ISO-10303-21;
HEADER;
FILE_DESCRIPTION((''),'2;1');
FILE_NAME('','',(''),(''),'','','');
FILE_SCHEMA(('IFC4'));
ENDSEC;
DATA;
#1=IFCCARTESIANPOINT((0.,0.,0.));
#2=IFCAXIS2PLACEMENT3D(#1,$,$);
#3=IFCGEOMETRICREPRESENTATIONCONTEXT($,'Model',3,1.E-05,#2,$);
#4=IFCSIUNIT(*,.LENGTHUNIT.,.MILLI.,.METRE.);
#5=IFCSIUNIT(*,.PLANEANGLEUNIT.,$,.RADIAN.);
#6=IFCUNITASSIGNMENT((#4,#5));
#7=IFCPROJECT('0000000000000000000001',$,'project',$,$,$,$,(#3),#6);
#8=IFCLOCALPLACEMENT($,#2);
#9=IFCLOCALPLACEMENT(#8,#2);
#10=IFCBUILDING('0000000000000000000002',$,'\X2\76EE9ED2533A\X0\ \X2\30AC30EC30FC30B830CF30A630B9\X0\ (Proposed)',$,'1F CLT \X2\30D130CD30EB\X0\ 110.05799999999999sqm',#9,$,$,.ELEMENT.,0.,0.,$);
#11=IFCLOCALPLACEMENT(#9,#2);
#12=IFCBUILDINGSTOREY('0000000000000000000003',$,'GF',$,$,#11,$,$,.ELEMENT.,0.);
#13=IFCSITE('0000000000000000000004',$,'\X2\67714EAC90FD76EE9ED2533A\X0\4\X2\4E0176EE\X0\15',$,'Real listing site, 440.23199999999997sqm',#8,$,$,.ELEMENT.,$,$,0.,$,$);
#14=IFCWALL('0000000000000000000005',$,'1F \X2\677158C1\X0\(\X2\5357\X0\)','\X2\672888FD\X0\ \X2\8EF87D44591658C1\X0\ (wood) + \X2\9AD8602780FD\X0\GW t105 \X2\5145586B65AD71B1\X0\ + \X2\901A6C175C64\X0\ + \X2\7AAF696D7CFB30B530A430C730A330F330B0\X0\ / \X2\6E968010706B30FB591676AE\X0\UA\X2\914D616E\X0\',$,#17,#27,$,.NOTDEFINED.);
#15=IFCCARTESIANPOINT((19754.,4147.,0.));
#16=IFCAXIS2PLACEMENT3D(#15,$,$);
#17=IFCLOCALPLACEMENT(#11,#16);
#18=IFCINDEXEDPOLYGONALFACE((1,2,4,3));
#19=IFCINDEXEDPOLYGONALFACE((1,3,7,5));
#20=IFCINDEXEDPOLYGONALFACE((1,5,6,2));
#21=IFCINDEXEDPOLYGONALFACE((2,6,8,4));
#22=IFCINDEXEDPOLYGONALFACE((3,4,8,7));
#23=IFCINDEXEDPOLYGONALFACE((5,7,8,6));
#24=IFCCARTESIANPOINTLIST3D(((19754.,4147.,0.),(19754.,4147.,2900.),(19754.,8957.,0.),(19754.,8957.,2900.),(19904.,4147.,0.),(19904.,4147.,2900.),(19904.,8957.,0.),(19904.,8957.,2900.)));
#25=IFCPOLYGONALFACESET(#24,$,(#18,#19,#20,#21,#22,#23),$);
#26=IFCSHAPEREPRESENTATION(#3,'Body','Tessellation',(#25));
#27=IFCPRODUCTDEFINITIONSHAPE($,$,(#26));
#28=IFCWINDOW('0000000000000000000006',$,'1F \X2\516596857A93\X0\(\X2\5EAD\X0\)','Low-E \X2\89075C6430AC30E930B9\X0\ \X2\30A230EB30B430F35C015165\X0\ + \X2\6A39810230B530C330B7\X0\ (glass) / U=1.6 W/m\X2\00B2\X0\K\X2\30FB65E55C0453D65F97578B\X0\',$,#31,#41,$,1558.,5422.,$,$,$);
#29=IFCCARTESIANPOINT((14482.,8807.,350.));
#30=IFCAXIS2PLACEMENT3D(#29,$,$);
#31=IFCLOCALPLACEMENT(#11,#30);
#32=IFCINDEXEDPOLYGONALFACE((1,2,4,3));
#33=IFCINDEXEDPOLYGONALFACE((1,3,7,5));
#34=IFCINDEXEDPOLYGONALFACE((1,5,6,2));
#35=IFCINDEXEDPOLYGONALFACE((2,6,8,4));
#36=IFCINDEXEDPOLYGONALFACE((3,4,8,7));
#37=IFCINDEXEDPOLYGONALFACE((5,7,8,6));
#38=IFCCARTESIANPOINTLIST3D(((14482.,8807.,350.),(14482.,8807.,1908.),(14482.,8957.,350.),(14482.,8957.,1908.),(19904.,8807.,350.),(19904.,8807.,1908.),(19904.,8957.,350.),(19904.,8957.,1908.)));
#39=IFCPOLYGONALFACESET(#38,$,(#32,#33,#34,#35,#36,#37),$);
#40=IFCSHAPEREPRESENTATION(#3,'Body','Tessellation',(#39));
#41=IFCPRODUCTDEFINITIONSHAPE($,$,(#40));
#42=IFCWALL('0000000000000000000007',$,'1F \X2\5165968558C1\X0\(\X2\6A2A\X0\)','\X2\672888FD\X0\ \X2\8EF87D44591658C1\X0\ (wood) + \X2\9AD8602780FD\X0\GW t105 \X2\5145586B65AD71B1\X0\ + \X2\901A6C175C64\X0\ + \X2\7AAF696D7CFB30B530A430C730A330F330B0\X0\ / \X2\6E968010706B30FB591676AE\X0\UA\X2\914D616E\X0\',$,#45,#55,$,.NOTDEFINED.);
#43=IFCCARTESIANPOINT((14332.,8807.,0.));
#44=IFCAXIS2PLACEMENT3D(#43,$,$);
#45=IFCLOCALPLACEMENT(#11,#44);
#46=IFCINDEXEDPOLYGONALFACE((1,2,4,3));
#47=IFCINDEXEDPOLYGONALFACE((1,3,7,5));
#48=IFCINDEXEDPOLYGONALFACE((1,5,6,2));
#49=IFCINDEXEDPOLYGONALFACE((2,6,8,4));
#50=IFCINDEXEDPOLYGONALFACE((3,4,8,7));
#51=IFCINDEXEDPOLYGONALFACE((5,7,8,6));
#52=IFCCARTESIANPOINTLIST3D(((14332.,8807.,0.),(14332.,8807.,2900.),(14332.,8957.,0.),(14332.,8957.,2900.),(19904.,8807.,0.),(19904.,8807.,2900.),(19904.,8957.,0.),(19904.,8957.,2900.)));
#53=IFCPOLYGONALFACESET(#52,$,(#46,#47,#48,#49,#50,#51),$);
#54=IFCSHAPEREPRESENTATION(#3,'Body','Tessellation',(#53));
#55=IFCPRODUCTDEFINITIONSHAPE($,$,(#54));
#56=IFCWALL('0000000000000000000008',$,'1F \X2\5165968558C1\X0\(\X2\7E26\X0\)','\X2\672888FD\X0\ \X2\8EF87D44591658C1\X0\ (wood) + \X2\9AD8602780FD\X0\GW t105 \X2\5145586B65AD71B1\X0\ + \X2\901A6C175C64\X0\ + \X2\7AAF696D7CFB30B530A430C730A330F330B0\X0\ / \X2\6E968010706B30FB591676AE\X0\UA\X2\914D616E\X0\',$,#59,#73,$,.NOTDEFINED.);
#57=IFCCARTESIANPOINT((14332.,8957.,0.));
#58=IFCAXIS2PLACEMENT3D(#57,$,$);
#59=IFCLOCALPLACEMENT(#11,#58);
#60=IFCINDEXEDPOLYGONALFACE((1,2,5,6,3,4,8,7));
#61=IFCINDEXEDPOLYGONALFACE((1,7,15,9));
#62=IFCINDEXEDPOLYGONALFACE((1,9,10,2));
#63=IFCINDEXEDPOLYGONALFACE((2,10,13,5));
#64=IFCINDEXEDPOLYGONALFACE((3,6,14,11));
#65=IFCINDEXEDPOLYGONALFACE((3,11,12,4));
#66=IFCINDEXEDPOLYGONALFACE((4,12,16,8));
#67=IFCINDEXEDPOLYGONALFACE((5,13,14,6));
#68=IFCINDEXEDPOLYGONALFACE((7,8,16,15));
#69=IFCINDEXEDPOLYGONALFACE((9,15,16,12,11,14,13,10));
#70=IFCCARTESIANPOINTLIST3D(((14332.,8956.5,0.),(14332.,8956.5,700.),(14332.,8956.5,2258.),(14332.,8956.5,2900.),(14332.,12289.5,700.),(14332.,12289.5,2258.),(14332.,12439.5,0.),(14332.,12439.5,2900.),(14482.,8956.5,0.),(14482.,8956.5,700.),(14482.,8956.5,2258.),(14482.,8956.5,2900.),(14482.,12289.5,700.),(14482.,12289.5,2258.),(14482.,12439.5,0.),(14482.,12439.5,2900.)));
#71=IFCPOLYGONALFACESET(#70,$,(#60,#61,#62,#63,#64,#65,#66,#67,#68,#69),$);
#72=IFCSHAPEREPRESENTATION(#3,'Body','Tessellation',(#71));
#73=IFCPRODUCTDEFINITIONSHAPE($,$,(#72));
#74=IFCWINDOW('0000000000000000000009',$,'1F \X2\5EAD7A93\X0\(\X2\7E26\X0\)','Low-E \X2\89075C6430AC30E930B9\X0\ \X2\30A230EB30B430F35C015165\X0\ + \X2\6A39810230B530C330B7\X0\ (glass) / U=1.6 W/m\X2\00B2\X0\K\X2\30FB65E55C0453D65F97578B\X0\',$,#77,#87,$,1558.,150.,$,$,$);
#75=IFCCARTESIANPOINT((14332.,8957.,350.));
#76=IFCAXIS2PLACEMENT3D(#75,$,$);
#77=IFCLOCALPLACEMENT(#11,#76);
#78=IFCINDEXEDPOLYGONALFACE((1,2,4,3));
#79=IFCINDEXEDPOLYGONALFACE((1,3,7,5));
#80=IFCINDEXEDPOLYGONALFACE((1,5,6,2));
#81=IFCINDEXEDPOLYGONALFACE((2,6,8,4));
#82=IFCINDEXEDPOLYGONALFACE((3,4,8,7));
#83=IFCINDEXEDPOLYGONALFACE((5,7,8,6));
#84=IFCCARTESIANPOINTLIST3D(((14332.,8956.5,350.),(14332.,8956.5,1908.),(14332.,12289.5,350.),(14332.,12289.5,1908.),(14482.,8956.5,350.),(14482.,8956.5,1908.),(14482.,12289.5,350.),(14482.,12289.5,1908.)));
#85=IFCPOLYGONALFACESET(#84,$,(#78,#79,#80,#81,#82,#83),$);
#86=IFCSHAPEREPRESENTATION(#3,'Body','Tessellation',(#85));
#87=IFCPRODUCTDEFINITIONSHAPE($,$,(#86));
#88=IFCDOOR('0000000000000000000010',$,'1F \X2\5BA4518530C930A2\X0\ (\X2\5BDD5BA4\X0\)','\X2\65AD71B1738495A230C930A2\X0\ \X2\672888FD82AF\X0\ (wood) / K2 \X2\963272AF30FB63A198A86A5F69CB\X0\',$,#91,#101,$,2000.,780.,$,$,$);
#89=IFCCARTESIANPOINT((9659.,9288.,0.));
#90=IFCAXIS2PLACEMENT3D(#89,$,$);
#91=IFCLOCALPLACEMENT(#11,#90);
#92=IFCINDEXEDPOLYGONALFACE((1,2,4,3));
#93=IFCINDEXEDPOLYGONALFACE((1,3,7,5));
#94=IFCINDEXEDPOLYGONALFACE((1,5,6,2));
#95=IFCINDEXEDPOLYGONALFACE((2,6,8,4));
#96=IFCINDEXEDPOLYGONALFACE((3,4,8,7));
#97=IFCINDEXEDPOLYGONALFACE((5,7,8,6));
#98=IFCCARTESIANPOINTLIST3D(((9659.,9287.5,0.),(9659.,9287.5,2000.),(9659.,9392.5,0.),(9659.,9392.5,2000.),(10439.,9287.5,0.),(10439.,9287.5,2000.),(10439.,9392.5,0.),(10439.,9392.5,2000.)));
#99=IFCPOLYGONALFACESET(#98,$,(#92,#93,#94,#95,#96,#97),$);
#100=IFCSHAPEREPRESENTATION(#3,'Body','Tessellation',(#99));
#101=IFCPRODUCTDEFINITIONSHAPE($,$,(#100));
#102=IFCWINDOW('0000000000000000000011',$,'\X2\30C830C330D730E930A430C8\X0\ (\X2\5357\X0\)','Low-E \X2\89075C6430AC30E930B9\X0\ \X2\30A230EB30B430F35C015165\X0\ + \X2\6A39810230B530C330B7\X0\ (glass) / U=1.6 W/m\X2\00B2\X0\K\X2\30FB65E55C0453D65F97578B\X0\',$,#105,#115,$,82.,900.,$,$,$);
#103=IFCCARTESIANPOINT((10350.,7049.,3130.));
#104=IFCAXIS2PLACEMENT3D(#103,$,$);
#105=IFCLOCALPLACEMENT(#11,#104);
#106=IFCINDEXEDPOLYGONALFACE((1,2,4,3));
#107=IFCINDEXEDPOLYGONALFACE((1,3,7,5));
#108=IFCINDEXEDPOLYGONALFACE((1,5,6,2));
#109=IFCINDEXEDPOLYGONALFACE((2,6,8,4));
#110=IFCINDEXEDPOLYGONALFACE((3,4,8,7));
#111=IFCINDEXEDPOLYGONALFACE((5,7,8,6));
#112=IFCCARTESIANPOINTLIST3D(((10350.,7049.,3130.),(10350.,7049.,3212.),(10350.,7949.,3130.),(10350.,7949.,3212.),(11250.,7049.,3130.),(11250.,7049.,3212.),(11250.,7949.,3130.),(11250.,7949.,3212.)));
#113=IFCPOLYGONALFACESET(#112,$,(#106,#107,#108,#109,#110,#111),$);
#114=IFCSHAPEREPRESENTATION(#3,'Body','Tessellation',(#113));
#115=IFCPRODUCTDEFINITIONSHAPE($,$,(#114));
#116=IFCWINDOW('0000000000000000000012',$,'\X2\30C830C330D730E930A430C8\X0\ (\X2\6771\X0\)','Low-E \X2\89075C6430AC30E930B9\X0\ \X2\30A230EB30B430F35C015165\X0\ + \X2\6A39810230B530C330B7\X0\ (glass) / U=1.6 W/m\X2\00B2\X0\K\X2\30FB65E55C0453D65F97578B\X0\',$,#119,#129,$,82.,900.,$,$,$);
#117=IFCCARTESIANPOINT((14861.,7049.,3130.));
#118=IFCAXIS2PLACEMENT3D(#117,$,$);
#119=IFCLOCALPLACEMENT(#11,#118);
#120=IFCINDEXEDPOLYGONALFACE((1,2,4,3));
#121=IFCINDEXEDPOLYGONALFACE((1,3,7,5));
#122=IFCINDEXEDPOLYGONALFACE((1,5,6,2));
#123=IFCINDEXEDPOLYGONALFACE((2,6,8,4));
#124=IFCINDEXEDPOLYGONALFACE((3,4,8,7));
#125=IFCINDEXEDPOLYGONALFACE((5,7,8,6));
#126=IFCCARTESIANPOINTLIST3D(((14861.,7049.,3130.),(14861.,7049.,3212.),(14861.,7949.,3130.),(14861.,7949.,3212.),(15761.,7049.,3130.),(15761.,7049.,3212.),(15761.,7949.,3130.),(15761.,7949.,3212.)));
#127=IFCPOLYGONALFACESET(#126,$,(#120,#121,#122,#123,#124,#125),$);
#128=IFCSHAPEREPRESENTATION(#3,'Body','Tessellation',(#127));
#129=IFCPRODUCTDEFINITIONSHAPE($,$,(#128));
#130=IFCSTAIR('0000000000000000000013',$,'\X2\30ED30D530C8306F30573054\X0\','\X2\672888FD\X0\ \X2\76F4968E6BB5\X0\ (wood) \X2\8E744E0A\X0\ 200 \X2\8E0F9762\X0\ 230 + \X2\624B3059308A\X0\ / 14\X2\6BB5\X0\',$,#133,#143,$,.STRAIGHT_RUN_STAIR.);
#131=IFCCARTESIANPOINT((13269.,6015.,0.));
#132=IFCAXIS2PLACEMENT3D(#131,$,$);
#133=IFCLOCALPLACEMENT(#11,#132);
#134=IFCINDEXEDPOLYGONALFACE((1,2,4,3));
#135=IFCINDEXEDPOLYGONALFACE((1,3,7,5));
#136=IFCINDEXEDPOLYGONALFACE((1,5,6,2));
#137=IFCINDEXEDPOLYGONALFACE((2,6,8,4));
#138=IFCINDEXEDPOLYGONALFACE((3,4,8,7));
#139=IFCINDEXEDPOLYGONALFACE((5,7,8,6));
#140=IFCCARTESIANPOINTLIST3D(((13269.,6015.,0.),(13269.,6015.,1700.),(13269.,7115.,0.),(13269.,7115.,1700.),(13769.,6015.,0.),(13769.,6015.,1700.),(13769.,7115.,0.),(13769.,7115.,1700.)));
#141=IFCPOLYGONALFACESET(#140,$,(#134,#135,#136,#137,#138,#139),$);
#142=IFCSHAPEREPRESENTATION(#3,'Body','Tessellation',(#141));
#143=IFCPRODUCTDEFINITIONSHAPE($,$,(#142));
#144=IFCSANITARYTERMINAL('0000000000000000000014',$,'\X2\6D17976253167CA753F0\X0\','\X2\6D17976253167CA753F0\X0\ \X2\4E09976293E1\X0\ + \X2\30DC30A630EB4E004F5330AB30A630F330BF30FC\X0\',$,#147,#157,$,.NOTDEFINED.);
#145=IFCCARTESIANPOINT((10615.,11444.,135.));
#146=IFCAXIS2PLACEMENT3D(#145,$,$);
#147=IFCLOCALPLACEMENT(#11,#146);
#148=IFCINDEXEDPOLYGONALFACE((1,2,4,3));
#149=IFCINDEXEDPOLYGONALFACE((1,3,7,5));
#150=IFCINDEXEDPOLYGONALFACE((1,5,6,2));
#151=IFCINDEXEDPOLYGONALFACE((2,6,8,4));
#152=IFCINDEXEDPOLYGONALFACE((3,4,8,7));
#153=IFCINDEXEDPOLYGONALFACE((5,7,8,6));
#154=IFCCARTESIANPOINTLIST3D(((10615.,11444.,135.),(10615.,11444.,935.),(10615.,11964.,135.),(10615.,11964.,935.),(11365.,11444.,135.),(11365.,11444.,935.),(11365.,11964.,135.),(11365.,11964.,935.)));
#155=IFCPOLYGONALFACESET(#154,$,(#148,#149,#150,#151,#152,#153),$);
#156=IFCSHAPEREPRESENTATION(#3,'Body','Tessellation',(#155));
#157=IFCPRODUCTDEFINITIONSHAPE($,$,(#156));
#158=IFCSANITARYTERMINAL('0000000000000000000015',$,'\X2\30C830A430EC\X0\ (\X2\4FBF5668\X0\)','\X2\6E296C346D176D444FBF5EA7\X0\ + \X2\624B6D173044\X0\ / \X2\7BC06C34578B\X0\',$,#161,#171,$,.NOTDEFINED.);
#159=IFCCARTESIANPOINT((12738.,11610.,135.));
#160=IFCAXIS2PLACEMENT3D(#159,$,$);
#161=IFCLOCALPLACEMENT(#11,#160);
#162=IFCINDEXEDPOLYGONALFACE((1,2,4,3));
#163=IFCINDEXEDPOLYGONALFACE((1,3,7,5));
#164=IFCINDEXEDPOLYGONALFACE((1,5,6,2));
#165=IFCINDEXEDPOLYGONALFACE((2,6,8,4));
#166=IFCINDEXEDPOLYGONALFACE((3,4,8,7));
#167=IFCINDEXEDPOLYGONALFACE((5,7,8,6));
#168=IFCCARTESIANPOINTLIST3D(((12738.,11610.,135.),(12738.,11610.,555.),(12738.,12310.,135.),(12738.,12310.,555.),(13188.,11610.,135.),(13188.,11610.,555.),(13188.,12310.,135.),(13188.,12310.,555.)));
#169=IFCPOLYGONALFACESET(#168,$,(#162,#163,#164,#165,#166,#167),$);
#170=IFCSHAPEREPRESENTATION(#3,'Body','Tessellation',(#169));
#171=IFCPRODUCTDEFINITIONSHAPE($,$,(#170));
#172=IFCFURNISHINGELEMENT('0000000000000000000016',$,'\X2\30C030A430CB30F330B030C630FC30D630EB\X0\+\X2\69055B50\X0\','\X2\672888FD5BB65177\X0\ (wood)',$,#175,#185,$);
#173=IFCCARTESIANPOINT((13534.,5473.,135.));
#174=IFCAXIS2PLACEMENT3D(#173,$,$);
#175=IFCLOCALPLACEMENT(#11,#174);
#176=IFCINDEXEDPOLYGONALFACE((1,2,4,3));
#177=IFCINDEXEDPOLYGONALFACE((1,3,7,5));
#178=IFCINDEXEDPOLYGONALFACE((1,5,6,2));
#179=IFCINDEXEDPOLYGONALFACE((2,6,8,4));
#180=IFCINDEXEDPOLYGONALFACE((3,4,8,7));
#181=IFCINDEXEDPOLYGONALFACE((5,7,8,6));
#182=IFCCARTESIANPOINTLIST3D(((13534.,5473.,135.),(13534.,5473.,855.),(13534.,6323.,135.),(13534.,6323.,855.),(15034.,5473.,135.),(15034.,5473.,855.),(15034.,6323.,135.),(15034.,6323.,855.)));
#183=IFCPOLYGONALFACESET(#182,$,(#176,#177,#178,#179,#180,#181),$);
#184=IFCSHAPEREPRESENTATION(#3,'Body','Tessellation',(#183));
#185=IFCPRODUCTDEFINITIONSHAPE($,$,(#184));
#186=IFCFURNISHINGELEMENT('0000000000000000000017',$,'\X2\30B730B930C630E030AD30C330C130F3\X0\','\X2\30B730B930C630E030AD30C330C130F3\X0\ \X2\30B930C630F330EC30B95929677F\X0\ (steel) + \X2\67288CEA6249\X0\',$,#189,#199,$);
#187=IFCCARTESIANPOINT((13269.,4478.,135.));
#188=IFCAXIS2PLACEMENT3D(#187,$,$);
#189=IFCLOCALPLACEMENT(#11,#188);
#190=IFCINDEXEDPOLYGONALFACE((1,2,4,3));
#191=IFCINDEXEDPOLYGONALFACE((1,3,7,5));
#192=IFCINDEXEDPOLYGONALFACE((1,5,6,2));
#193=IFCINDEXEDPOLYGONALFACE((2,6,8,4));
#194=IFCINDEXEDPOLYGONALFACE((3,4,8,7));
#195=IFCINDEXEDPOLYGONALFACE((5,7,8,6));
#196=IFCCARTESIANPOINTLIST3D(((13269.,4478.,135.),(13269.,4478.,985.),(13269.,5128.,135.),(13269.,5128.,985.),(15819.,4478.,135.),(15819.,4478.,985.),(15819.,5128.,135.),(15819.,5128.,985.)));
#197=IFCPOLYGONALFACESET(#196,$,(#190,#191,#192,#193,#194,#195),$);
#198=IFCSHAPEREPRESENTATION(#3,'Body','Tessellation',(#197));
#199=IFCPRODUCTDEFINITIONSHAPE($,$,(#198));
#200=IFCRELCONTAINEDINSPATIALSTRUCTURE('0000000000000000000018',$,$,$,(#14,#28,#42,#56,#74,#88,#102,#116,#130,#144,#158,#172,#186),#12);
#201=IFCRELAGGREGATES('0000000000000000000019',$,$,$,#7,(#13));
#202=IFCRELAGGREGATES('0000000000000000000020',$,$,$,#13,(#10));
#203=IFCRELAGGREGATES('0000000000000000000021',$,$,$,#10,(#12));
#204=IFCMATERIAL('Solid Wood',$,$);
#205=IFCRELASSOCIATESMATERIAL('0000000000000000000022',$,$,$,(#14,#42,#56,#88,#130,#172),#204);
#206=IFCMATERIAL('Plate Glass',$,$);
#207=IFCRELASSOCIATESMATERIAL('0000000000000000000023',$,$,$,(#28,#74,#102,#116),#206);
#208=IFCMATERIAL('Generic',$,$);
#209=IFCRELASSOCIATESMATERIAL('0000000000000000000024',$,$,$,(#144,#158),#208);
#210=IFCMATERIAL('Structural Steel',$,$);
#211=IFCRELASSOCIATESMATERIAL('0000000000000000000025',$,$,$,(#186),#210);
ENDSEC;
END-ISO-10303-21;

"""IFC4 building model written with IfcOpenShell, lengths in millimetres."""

from ifc_helpers import new_model, si_unit, frame, frame_2d, origin, place, context, project, spatial, rectangle, extrude, material, element, fill, save


model = new_model("IFC4")

# Units and contexts
model_context = context("Model", 3, precision=1e-05, world=origin())
ifc_project = project(units=[si_unit("LENGTHUNIT", "METRE", prefix="MILLI"), si_unit("PLANEANGLEUNIT", "RADIAN")], contexts=[model_context])

# Site, building, storey
site_placement = place(None, origin())
site = spatial("IfcSite", under=ifc_project, at=site_placement, Name="東京都目黒区4丁目15", ObjectType="Real listing site, 440.23199999999997sqm", CompositionType="ELEMENT", RefElevation=0.0)
building_placement = place(site_placement, origin())
building = spatial("IfcBuilding", under=site, at=building_placement, Name="目黒区 ガレージハウス (Proposed)", ObjectType="1F CLT パネル 110.05799999999999sqm", CompositionType="ELEMENT", ElevationOfRefHeight=0.0, ElevationOfTerrain=0.0)
storey_placement = place(building_placement, origin())
storey = spatial("IfcBuildingStorey", under=building, at=storey_placement, Name="GF", CompositionType="ELEMENT", Elevation=0.0)

# Shared definitions
ifc_material_1 = material(Name="Solid Wood")

# Wall, opening, window
wall_1_placement = place(storey_placement, frame((19754.0, 4147.0, 0.0)))
wall_1 = element("IfcWall", 1, at=wall_1_placement, inside=storey, material=ifc_material_1, Name="1F 東壁(南)", Description="木製 軸組外壁 (wood) + 高性能GW t105 充填断熱 + 通気層 + 窯業系サイディング / 準耐火・外皮UA配慮", PredefinedType="NOTDEFINED", context=model_context, shape_type="SweptSolid", body=[
    extrude(rectangle(XDim=150.0, YDim=4810.0, at=frame_2d((75.0, 2405.0))), frame((19754.0, 4147.0, 0.0)), (0.0, 0.0, 1.0), 2900.0),
])
opening_1_placement = place(storey_placement, frame((14482.0, 8807.0, 350.0)))
opening_1 = element("IfcOpeningElement", 2, at=opening_1_placement, cuts=wall_1, PredefinedType="NOTDEFINED", context=model_context, shape_type="SweptSolid", body=[
    extrude(rectangle(XDim=5422.0, YDim=150.0, at=frame_2d((2711.0, 75.0))), frame((14482.0, 8807.0, 350.0)), (0.0, 0.0, 1.0), 1558.0),
])
ifc_material_2 = material(Name="Plate Glass")
window_1_placement = place(storey_placement, frame((14482.0, 8807.0, 350.0)))
window_1 = element("IfcWindow", 3, at=window_1_placement, inside=storey, material=ifc_material_2, Name="1F 入隅窓(庭)", Description="Low-E 複層ガラス アルゴン封入 + 樹脂サッシ (glass) / U=1.6 W/m²K・日射取得型", OverallHeight=1558.0, OverallWidth=5422.0, context=model_context, shape_type="SweptSolid", body=[
    extrude(rectangle(XDim=5422.0, YDim=150.0, at=frame_2d((2711.0, 75.0))), frame((14482.0, 8807.0, 350.0)), (0.0, 0.0, 1.0), 1558.0),
])
fill(opening_1, window_1)

# Wall
wall_2_placement = place(storey_placement, frame((14332.0, 8807.0, 0.0)))
element("IfcWall", 4, at=wall_2_placement, inside=storey, material=ifc_material_1, Name="1F 入隅壁(横)", Description="木製 軸組外壁 (wood) + 高性能GW t105 充填断熱 + 通気層 + 窯業系サイディング / 準耐火・外皮UA配慮", PredefinedType="NOTDEFINED", context=model_context, shape_type="SweptSolid", body=[
    extrude(rectangle(XDim=5572.0, YDim=150.0, at=frame_2d((2786.0, 75.0))), frame((14332.0, 8807.0, 0.0)), (0.0, 0.0, 1.0), 2900.0),
])

# Wall, opening, window
wall_3_placement = place(storey_placement, frame((14332.0, 8957.0, 0.0)))
wall_3 = element("IfcWall", 5, at=wall_3_placement, inside=storey, material=ifc_material_1, Name="1F 入隅壁(縦)", Description="木製 軸組外壁 (wood) + 高性能GW t105 充填断熱 + 通気層 + 窯業系サイディング / 準耐火・外皮UA配慮", PredefinedType="NOTDEFINED", context=model_context, shape_type="SweptSolid", body=[
    extrude(rectangle(XDim=150.0, YDim=3483.0, at=frame_2d((75.0, 1741.0))), frame((14332.0, 8957.0, 0.0)), (0.0, 0.0, 1.0), 2900.0),
])
opening_2_placement = place(storey_placement, frame((14332.0, 8957.0, 350.0)))
opening_2 = element("IfcOpeningElement", 6, at=opening_2_placement, cuts=wall_3, PredefinedType="NOTDEFINED", context=model_context, shape_type="SweptSolid", body=[
    extrude(rectangle(XDim=150.0, YDim=3333.0, at=frame_2d((75.0, 1666.0))), frame((14332.0, 8957.0, 350.0)), (0.0, 0.0, 1.0), 1558.0),
])
window_2_placement = place(storey_placement, frame((14332.0, 8957.0, 350.0)))
window_2 = element("IfcWindow", 7, at=window_2_placement, inside=storey, material=ifc_material_2, Name="1F 庭窓(縦)", Description="Low-E 複層ガラス アルゴン封入 + 樹脂サッシ (glass) / U=1.6 W/m²K・日射取得型", OverallHeight=1558.0, OverallWidth=150.0, context=model_context, shape_type="SweptSolid", body=[
    extrude(rectangle(XDim=150.0, YDim=3333.0, at=frame_2d((75.0, 1666.0))), frame((14332.0, 8957.0, 350.0)), (0.0, 0.0, 1.0), 1558.0),
])
fill(opening_2, window_2)

# Door
door_placement = place(storey_placement, frame((9659.0, 9288.0, 0.0)))
element("IfcDoor", 8, at=door_placement, inside=storey, material=ifc_material_1, Name="1F 室内ドア (寝室)", Description="断熱玄関ドア 木製芯 (wood) / K2 防犯・採風機構", OverallHeight=2000.0, OverallWidth=780.0, context=model_context, shape_type="SweptSolid", body=[
    extrude(rectangle(XDim=780.0, YDim=105.0, at=frame_2d((390.0, 52.0))), frame((9659.0, 9288.0, 0.0)), (0.0, 0.0, 1.0), 2000.0),
])

# Windows
window_3_placement = place(storey_placement, frame((10350.0, 7049.0, 3130.0)))
element("IfcWindow", 9, at=window_3_placement, inside=storey, material=ifc_material_2, Name="トップライト (南)", Description="Low-E 複層ガラス アルゴン封入 + 樹脂サッシ (glass) / U=1.6 W/m²K・日射取得型", OverallHeight=82.0, OverallWidth=900.0, context=model_context, shape_type="SweptSolid", body=[
    extrude(rectangle(XDim=900.0, YDim=900.0, at=frame_2d((450.0, 450.0))), frame((10350.0, 7049.0, 3130.0)), (0.0, 0.0, 1.0), 82.0),
])
window_4_placement = place(storey_placement, frame((14861.0, 7049.0, 3130.0)))
element("IfcWindow", 10, at=window_4_placement, inside=storey, material=ifc_material_2, Name="トップライト (東)", Description="Low-E 複層ガラス アルゴン封入 + 樹脂サッシ (glass) / U=1.6 W/m²K・日射取得型", OverallHeight=82.0, OverallWidth=900.0, context=model_context, shape_type="SweptSolid", body=[
    extrude(rectangle(XDim=900.0, YDim=900.0, at=frame_2d((450.0, 450.0))), frame((14861.0, 7049.0, 3130.0)), (0.0, 0.0, 1.0), 82.0),
])

# Stair
stair_placement = place(storey_placement, frame((13269.0, 6015.0, 0.0)))
element("IfcStair", 11, at=stair_placement, inside=storey, material=ifc_material_1, Name="ロフトはしご", Description="木製 直階段 (wood) 蹴上 200 踏面 230 + 手すり / 14段", PredefinedType="STRAIGHT_RUN_STAIR", context=model_context, shape_type="SweptSolid", body=[
    extrude(rectangle(XDim=500.0, YDim=1100.0, at=frame_2d((250.0, 550.0))), frame((13269.0, 6015.0, 0.0)), (0.0, 0.0, 1.0), 1700.0),
])

# Sanitary terminals
ifc_material_3 = material(Name="Generic")
sanitary_terminal_1_placement = place(storey_placement, frame((10615.0, 11444.0, 135.0)))
element("IfcSanitaryTerminal", 12, at=sanitary_terminal_1_placement, inside=storey, material=ifc_material_3, Name="洗面化粧台", Description="洗面化粧台 三面鏡 + ボウル一体カウンター", PredefinedType="NOTDEFINED", context=model_context, shape_type="SweptSolid", body=[
    extrude(rectangle(XDim=750.0, YDim=520.0, at=frame_2d((375.0, 260.0))), frame((10615.0, 11444.0, 135.0)), (0.0, 0.0, 1.0), 800.0),
])
sanitary_terminal_2_placement = place(storey_placement, frame((12738.0, 11610.0, 135.0)))
element("IfcSanitaryTerminal", 13, at=sanitary_terminal_2_placement, inside=storey, material=ifc_material_3, Name="トイレ (便器)", Description="温水洗浄便座 + 手洗い / 節水型", PredefinedType="NOTDEFINED", context=model_context, shape_type="SweptSolid", body=[
    extrude(rectangle(XDim=450.0, YDim=700.0, at=frame_2d((225.0, 350.0))), frame((12738.0, 11610.0, 135.0)), (0.0, 0.0, 1.0), 420.0),
])

# Furnishing elements
furnishing_1_placement = place(storey_placement, frame((13534.0, 5473.0, 135.0)))
element("IfcFurnishingElement", 14, at=furnishing_1_placement, inside=storey, material=ifc_material_1, Name="ダイニングテーブル+椅子", Description="木製家具 (wood)", context=model_context, shape_type="SweptSolid", body=[
    extrude(rectangle(XDim=1500.0, YDim=850.0, at=frame_2d((750.0, 425.0))), frame((13534.0, 5473.0, 135.0)), (0.0, 0.0, 1.0), 720.0),
])
ifc_material_4 = material(Name="Structural Steel")
furnishing_2_placement = place(storey_placement, frame((13269.0, 4478.0, 135.0)))
element("IfcFurnishingElement", 15, at=furnishing_2_placement, inside=storey, material=ifc_material_4, Name="システムキッチン", Description="システムキッチン ステンレス天板 (steel) + 木質扉", context=model_context, shape_type="SweptSolid", body=[
    extrude(rectangle(XDim=2550.0, YDim=650.0, at=frame_2d((1275.0, 325.0))), frame((13269.0, 4478.0, 135.0)), (0.0, 0.0, 1.0), 850.0),
])

save(model, "model.ifc")
